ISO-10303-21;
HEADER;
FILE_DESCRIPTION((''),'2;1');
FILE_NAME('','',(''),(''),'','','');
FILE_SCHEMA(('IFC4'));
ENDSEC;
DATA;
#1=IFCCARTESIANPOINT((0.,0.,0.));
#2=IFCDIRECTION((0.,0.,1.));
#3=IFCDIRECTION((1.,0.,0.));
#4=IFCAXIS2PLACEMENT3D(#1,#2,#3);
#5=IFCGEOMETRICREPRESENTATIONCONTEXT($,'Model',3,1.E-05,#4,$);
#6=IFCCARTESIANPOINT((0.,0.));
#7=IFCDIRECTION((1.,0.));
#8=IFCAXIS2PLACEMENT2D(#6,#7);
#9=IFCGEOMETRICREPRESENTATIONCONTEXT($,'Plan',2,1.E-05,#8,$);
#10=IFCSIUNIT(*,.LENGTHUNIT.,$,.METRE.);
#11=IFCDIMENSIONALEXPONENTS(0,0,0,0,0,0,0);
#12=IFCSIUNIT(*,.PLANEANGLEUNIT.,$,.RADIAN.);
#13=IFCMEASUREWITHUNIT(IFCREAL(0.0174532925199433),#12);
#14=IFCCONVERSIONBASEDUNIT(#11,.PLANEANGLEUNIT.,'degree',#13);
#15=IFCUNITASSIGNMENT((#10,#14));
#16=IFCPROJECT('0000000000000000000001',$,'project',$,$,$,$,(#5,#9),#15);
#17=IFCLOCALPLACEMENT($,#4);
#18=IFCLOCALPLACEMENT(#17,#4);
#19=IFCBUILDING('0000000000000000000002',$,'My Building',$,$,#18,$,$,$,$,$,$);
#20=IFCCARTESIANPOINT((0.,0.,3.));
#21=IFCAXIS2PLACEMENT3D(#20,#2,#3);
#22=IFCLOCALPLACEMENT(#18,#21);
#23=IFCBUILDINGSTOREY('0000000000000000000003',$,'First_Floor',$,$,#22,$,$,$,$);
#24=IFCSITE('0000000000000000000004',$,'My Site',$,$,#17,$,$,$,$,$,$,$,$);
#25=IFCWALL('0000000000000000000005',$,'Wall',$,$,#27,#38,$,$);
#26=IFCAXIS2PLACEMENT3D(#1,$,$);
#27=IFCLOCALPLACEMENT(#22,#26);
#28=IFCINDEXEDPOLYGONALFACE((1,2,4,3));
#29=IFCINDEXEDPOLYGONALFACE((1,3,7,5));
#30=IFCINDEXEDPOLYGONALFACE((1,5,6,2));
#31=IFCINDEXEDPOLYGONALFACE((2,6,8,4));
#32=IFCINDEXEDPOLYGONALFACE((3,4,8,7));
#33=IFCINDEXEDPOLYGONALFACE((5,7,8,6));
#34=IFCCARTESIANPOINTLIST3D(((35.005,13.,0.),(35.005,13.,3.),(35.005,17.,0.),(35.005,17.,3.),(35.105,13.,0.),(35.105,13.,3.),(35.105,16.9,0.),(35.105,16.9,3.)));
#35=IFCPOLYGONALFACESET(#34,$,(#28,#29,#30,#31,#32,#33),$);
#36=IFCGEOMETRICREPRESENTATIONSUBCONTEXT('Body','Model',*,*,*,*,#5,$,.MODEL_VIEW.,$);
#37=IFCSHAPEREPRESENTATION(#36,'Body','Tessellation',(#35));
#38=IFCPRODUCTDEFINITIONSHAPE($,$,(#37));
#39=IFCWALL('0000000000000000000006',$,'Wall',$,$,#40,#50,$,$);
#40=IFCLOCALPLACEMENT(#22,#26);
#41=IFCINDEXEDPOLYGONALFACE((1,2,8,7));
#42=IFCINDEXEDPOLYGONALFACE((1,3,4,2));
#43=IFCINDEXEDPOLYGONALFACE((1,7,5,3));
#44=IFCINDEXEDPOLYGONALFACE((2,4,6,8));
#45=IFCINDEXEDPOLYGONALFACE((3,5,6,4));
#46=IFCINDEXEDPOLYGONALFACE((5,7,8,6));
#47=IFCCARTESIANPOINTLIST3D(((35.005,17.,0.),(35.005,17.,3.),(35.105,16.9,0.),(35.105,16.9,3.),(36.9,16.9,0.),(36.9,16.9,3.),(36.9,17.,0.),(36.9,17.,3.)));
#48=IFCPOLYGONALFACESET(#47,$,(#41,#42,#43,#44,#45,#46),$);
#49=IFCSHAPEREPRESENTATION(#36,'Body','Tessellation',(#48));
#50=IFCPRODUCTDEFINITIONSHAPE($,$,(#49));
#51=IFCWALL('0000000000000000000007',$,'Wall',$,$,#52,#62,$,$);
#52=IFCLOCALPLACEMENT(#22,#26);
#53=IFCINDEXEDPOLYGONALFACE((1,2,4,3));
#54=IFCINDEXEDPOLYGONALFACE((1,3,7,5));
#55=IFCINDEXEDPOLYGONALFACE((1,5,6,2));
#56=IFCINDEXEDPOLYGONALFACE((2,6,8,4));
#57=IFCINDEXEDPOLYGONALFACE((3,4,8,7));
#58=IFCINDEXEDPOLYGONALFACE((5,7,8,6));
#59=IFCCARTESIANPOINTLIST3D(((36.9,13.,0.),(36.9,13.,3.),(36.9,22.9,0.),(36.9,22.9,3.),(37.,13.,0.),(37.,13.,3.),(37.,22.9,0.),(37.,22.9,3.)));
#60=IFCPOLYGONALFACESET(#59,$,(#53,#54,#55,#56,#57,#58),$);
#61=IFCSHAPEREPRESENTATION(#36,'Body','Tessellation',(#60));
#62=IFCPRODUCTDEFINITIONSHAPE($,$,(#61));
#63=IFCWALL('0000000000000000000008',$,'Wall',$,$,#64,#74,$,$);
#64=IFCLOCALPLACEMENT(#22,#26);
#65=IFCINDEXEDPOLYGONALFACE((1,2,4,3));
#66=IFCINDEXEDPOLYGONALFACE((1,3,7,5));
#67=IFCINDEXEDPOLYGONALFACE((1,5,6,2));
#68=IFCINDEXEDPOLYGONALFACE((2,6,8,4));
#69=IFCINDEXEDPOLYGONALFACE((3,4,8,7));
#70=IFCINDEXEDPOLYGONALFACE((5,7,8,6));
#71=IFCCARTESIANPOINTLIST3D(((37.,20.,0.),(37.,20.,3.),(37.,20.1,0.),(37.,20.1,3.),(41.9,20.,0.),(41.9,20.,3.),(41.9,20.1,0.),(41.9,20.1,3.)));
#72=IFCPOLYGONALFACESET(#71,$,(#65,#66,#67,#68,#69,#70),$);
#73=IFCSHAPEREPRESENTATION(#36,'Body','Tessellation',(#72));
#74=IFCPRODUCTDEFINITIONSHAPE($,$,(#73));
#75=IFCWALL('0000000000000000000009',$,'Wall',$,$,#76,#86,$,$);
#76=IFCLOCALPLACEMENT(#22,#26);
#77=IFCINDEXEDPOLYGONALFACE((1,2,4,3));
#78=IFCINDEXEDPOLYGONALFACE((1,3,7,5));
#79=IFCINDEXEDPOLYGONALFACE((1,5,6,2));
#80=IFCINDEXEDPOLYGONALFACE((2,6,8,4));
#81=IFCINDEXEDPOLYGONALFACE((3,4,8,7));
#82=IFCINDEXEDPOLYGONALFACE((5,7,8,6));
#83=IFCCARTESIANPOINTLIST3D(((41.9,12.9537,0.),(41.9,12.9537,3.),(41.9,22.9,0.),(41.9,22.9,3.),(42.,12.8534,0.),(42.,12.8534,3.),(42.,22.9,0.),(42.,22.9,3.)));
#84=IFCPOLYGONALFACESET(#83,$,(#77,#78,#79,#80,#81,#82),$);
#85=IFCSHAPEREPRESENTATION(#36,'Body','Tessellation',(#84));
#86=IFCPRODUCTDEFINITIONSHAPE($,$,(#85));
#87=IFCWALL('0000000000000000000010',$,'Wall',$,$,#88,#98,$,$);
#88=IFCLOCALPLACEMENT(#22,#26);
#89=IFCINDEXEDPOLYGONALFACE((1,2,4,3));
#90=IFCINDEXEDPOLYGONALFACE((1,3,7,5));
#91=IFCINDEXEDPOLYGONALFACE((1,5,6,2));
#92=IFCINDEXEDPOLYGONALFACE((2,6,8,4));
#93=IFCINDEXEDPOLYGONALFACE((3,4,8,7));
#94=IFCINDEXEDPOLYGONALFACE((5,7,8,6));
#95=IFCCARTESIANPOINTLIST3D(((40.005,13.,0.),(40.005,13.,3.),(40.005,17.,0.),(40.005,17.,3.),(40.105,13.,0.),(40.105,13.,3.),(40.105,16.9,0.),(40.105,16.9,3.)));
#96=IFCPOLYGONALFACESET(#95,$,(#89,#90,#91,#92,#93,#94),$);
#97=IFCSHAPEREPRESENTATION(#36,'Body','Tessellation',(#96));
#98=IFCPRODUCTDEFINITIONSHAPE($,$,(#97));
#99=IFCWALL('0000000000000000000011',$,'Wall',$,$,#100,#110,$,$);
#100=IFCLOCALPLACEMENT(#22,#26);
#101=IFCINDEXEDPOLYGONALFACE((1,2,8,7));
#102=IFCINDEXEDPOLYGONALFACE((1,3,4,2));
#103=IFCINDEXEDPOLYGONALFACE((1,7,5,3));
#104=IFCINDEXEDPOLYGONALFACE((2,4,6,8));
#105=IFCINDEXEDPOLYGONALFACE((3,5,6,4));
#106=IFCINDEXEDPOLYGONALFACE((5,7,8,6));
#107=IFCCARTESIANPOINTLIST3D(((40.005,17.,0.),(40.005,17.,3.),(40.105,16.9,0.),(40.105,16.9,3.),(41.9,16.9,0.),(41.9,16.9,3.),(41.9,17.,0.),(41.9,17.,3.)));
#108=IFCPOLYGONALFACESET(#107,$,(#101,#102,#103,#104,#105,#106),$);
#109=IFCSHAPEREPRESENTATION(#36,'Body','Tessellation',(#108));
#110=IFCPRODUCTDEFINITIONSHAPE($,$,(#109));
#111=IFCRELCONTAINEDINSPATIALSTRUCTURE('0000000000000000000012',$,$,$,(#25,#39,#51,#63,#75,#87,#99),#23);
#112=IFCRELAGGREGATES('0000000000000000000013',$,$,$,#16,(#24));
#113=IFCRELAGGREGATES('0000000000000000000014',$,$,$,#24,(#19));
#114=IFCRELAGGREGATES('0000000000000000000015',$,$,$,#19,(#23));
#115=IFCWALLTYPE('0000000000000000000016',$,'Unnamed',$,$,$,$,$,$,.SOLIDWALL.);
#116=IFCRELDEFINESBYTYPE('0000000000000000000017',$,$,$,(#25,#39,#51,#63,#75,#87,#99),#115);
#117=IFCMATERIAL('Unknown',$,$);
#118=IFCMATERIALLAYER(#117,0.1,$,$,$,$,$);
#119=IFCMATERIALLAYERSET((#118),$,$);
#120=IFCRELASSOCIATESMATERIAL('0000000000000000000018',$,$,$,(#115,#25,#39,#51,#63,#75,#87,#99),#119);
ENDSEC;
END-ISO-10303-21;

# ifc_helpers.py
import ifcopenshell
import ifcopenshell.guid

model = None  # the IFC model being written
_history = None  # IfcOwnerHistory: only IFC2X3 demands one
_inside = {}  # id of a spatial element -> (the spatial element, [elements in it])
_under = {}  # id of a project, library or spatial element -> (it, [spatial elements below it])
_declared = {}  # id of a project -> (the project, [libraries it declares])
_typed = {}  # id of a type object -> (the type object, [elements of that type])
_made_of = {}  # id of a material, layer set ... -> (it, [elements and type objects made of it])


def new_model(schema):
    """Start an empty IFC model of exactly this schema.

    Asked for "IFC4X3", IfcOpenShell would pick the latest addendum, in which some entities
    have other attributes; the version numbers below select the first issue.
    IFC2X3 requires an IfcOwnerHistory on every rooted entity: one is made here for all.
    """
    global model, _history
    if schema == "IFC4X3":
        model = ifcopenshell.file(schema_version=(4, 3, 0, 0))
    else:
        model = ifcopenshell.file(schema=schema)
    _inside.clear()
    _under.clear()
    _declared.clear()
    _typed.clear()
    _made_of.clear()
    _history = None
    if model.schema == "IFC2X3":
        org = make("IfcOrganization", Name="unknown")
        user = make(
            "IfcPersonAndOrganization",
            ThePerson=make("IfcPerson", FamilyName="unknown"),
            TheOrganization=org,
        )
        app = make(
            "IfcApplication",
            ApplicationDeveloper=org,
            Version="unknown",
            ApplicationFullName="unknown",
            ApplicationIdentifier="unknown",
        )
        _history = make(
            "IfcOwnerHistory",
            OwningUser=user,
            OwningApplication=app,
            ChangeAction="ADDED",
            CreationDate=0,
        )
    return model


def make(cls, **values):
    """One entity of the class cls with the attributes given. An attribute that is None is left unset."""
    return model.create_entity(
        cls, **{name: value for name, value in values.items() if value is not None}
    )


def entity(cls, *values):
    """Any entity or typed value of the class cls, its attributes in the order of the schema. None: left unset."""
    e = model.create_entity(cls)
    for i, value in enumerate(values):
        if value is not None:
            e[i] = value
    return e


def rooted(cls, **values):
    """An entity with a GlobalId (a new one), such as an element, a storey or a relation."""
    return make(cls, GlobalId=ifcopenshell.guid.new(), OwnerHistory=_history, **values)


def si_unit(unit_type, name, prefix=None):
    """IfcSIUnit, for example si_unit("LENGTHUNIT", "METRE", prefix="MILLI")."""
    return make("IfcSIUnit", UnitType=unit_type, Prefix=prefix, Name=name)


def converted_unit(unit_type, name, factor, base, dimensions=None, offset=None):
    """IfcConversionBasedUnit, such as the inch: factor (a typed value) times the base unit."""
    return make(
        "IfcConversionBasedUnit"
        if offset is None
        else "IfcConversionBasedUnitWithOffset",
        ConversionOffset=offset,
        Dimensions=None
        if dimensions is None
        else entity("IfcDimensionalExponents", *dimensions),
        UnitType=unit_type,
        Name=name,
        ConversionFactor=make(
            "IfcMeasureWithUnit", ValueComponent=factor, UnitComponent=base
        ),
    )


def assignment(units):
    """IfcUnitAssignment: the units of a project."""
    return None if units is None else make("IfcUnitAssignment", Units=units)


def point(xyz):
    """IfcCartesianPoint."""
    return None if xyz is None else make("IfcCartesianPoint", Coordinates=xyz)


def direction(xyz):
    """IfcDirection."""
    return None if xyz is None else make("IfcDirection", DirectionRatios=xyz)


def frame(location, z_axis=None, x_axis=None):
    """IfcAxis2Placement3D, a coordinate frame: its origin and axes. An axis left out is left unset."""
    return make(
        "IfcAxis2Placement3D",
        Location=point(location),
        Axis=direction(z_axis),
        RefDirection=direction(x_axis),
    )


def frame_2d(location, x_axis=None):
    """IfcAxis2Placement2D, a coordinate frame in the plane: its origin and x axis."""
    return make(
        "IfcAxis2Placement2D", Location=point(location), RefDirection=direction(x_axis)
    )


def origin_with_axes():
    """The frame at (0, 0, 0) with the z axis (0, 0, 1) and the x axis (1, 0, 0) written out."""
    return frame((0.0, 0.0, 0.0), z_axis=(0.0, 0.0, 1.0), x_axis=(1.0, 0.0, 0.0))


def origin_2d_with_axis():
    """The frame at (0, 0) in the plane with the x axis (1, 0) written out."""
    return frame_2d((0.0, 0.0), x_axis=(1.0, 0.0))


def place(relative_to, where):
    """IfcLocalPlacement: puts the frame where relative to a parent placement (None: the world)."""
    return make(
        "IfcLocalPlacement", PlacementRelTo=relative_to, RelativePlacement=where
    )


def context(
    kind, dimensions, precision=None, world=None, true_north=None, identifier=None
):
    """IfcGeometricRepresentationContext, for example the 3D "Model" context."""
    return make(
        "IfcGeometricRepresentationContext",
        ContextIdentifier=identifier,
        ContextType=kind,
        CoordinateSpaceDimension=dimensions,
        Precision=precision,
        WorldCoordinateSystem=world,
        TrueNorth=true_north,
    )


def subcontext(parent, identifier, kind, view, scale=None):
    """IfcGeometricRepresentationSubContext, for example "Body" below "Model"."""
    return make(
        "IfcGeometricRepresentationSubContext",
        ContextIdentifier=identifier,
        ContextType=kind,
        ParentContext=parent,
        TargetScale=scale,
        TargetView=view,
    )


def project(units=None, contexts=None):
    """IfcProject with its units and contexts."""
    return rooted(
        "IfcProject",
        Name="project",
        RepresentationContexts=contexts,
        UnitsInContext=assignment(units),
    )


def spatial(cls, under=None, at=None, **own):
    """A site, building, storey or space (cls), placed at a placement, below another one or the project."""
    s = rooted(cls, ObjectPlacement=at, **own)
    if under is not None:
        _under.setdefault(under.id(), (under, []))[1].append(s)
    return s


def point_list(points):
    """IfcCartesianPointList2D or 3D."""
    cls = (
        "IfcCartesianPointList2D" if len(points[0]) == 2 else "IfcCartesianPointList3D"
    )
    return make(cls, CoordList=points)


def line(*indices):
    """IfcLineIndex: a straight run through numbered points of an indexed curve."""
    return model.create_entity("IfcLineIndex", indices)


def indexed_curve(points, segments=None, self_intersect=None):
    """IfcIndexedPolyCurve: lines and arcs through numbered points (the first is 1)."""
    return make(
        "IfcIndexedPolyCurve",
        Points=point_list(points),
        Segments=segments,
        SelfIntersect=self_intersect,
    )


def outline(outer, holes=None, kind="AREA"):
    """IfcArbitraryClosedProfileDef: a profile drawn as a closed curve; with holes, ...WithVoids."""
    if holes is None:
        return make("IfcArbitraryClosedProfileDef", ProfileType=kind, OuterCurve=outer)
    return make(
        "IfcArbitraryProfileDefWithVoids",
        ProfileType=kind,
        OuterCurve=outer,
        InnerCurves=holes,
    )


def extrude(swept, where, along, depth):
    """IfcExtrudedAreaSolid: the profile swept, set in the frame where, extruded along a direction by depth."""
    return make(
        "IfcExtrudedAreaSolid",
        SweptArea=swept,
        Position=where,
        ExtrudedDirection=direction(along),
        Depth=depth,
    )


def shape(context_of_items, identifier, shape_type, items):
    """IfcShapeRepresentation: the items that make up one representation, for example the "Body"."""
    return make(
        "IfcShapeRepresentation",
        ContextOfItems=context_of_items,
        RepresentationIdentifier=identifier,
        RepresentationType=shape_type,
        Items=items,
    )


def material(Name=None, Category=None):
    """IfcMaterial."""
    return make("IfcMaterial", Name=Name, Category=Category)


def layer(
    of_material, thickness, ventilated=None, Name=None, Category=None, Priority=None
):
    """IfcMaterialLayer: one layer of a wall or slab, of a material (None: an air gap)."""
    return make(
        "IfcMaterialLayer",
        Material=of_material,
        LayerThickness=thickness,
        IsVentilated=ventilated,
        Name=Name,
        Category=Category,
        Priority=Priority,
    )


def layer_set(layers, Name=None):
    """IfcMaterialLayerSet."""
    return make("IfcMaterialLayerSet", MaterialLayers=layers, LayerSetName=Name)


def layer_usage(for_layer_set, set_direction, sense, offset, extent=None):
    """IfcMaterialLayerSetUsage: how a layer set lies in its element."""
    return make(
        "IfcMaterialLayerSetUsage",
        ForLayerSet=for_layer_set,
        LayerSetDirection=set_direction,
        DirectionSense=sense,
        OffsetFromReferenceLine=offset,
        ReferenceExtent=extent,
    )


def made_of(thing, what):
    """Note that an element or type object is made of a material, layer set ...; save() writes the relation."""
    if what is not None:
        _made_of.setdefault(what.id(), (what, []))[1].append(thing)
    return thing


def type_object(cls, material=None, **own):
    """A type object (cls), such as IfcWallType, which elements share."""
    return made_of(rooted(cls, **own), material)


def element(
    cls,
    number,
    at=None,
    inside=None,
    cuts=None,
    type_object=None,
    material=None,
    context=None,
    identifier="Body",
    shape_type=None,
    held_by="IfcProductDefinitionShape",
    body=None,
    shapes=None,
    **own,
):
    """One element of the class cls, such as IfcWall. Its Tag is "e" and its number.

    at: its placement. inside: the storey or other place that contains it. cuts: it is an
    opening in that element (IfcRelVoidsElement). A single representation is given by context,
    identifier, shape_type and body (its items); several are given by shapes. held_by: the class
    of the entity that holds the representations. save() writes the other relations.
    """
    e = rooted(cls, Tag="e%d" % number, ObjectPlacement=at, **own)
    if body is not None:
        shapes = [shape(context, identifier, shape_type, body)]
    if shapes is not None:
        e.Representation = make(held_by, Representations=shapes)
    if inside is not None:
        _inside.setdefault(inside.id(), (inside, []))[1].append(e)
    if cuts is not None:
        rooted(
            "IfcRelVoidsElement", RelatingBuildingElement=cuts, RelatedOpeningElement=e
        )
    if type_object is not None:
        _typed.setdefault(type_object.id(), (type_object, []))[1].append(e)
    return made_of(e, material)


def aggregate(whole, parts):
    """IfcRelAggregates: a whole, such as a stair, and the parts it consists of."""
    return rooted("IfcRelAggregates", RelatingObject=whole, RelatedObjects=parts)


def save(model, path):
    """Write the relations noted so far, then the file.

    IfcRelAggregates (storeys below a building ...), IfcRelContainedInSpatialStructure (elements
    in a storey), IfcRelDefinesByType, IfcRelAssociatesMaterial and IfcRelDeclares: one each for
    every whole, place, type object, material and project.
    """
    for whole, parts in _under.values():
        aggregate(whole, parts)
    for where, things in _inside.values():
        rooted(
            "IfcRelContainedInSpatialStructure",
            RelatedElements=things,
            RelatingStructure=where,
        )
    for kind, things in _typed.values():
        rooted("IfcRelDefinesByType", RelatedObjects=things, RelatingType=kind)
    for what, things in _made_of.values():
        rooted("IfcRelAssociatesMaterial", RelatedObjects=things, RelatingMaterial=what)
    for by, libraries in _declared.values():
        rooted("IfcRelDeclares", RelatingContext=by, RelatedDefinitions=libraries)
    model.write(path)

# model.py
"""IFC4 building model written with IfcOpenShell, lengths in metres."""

from ifc_helpers import new_model, entity, si_unit, converted_unit, frame, origin_with_axes, origin_2d_with_axis, place, context, subcontext, project, spatial, line, indexed_curve, outline, extrude, material, layer, layer_set, layer_usage, type_object, element, save


model = new_model("IFC4")

# Units and contexts
model_context = context("Model", 3, precision=1e-05, world=origin_with_axes())
plan_context = context("Plan", 2, precision=1e-05, world=origin_2d_with_axis())
body_context = subcontext(model_context, "Body", "Model", "MODEL_VIEW")
ifc_project = project(units=[si_unit("LENGTHUNIT", "METRE"), converted_unit("PLANEANGLEUNIT", "degree", entity("IfcReal", 0.0174532925199433), si_unit("PLANEANGLEUNIT", "RADIAN"), dimensions=[0, 0, 0, 0, 0, 0, 0])], contexts=[model_context, plan_context])

# Site, building, storey
site_placement = place(None, origin_with_axes())
site = spatial("IfcSite", under=ifc_project, at=site_placement, Name="My Site")
building_placement = place(site_placement, origin_with_axes())
building = spatial("IfcBuilding", under=site, at=building_placement, Name="My Building")
storey_placement = place(building_placement, frame((0.0, 0.0, 3.0), z_axis=(0.0, 0.0, 1.0), x_axis=(1.0, 0.0, 0.0)))
storey = spatial("IfcBuildingStorey", under=building, at=storey_placement, Name="First_Floor")

# Walls
ifc_material = material(Name="Unknown")
ifc_layer = layer(ifc_material, 0.1)
ifc_layer_set = layer_set([ifc_layer])
wall_type = type_object("IfcWallType", Name="Unnamed", PredefinedType="SOLIDWALL", material=ifc_layer_set)
ifc_layer_usage_1 = layer_usage(ifc_layer_set, "AXIS2", "POSITIVE", 0.0)
wall_1_placement = place(storey_placement, frame((35.005, 17.0, 0.0), z_axis=(0.0, 0.0, 1.0), x_axis=(0.0, -1.0, 0.0)))
element("IfcWall", 1, at=wall_1_placement, inside=storey, type_object=wall_type, material=ifc_layer_usage_1, Name="Wall", context=body_context, shape_type="SweptSolid", body=[
    extrude(outline(indexed_curve([(0.0, 0.0), (0.1, 0.1), (4.0, 0.1), (4.0, 0.0)], segments=[line(1, 2, 3, 4, 1)])), origin_with_axes(), (0.0, 0.0, 1.0), 3.0),
])
ifc_layer_usage_2 = layer_usage(ifc_layer_set, "AXIS2", "POSITIVE", 0.0)
wall_2_placement = place(storey_placement, frame((36.9, 17.0, 0.0), z_axis=(0.0, 0.0, 1.0), x_axis=(-1.0, 0.0, 0.0)))
element("IfcWall", 2, at=wall_2_placement, inside=storey, type_object=wall_type, material=ifc_layer_usage_2, Name="Wall", context=body_context, shape_type="SweptSolid", body=[
    extrude(outline(indexed_curve([(0.0, 0.0), (0.0, 0.1), (1.795, 0.1), (1.895, 0.0)], segments=[line(1, 2, 3, 4, 1)])), origin_with_axes(), (0.0, 0.0, 1.0), 3.0),
])
ifc_layer_usage_3 = layer_usage(ifc_layer_set, "AXIS2", "POSITIVE", 0.0)
wall_3_placement = place(storey_placement, frame((36.9, 22.9, 0.0), z_axis=(0.0, 0.0, 1.0), x_axis=(0.0, -1.0, 0.0)))
element("IfcWall", 3, at=wall_3_placement, inside=storey, type_object=wall_type, material=ifc_layer_usage_3, Name="Wall", context=body_context, shape_type="SweptSolid", body=[
    extrude(outline(indexed_curve([(0.0, 0.0), (0.0, 0.1), (9.9, 0.1), (9.9, 0.0)], segments=[line(1, 2, 3, 4, 1)])), origin_with_axes(), (0.0, 0.0, 1.0), 3.0),
])
ifc_layer_usage_4 = layer_usage(ifc_layer_set, "AXIS2", "POSITIVE", 0.0)
wall_4_placement = place(storey_placement, frame((37.0, 20.0, 0.0), z_axis=(0.0, 0.0, 1.0), x_axis=(1.0, 0.0, 0.0)))
element("IfcWall", 4, at=wall_4_placement, inside=storey, type_object=wall_type, material=ifc_layer_usage_4, Name="Wall", context=body_context, shape_type="SweptSolid", body=[
    extrude(outline(indexed_curve([(0.0, 0.0), (0.0, 0.1), (4.9, 0.1), (4.9, 0.0)], segments=[line(1, 2, 3, 4, 1)])), origin_with_axes(), (0.0, 0.0, 1.0), 3.0),
])
ifc_layer_usage_5 = layer_usage(ifc_layer_set, "AXIS2", "POSITIVE", 0.0)
wall_5_placement = place(storey_placement, frame((41.9, 22.9, 0.0), z_axis=(0.0, 0.0, 1.0), x_axis=(0.0, -1.0, 0.0)))
element("IfcWall", 5, at=wall_5_placement, inside=storey, type_object=wall_type, material=ifc_layer_usage_5, Name="Wall", context=body_context, shape_type="SweptSolid", body=[
    extrude(outline(indexed_curve([(0.0, 0.0), (0.0, 0.1), (10.0466, 0.1), (9.9463, 0.0)], segments=[line(1, 2, 3, 4, 1)])), origin_with_axes(), (0.0, 0.0, 1.0), 3.0),
])
ifc_layer_usage_6 = layer_usage(ifc_layer_set, "AXIS2", "POSITIVE", 0.0)
wall_6_placement = place(storey_placement, frame((40.005, 17.0, 0.0), z_axis=(0.0, 0.0, 1.0), x_axis=(0.0, -1.0, 0.0)))
element("IfcWall", 6, at=wall_6_placement, inside=storey, type_object=wall_type, material=ifc_layer_usage_6, Name="Wall", context=body_context, shape_type="SweptSolid", body=[
    extrude(outline(indexed_curve([(0.0, 0.0), (0.1, 0.1), (4.0, 0.1), (4.0, 0.0)], segments=[line(1, 2, 3, 4, 1)])), origin_with_axes(), (0.0, 0.0, 1.0), 3.0),
])
ifc_layer_usage_7 = layer_usage(ifc_layer_set, "AXIS2", "POSITIVE", 0.0)
wall_7_placement = place(storey_placement, frame((41.9, 17.0, 0.0), z_axis=(0.0, 0.0, 1.0), x_axis=(-1.0, 0.0, 0.0)))
element("IfcWall", 7, at=wall_7_placement, inside=storey, type_object=wall_type, material=ifc_layer_usage_7, Name="Wall", context=body_context, shape_type="SweptSolid", body=[
    extrude(outline(indexed_curve([(0.0, 0.0), (0.0, 0.1), (1.795, 0.1), (1.895, 0.0)], segments=[line(1, 2, 3, 4, 1)])), origin_with_axes(), (0.0, 0.0, 1.0), 3.0),
])

save(model, "model.ifc")
